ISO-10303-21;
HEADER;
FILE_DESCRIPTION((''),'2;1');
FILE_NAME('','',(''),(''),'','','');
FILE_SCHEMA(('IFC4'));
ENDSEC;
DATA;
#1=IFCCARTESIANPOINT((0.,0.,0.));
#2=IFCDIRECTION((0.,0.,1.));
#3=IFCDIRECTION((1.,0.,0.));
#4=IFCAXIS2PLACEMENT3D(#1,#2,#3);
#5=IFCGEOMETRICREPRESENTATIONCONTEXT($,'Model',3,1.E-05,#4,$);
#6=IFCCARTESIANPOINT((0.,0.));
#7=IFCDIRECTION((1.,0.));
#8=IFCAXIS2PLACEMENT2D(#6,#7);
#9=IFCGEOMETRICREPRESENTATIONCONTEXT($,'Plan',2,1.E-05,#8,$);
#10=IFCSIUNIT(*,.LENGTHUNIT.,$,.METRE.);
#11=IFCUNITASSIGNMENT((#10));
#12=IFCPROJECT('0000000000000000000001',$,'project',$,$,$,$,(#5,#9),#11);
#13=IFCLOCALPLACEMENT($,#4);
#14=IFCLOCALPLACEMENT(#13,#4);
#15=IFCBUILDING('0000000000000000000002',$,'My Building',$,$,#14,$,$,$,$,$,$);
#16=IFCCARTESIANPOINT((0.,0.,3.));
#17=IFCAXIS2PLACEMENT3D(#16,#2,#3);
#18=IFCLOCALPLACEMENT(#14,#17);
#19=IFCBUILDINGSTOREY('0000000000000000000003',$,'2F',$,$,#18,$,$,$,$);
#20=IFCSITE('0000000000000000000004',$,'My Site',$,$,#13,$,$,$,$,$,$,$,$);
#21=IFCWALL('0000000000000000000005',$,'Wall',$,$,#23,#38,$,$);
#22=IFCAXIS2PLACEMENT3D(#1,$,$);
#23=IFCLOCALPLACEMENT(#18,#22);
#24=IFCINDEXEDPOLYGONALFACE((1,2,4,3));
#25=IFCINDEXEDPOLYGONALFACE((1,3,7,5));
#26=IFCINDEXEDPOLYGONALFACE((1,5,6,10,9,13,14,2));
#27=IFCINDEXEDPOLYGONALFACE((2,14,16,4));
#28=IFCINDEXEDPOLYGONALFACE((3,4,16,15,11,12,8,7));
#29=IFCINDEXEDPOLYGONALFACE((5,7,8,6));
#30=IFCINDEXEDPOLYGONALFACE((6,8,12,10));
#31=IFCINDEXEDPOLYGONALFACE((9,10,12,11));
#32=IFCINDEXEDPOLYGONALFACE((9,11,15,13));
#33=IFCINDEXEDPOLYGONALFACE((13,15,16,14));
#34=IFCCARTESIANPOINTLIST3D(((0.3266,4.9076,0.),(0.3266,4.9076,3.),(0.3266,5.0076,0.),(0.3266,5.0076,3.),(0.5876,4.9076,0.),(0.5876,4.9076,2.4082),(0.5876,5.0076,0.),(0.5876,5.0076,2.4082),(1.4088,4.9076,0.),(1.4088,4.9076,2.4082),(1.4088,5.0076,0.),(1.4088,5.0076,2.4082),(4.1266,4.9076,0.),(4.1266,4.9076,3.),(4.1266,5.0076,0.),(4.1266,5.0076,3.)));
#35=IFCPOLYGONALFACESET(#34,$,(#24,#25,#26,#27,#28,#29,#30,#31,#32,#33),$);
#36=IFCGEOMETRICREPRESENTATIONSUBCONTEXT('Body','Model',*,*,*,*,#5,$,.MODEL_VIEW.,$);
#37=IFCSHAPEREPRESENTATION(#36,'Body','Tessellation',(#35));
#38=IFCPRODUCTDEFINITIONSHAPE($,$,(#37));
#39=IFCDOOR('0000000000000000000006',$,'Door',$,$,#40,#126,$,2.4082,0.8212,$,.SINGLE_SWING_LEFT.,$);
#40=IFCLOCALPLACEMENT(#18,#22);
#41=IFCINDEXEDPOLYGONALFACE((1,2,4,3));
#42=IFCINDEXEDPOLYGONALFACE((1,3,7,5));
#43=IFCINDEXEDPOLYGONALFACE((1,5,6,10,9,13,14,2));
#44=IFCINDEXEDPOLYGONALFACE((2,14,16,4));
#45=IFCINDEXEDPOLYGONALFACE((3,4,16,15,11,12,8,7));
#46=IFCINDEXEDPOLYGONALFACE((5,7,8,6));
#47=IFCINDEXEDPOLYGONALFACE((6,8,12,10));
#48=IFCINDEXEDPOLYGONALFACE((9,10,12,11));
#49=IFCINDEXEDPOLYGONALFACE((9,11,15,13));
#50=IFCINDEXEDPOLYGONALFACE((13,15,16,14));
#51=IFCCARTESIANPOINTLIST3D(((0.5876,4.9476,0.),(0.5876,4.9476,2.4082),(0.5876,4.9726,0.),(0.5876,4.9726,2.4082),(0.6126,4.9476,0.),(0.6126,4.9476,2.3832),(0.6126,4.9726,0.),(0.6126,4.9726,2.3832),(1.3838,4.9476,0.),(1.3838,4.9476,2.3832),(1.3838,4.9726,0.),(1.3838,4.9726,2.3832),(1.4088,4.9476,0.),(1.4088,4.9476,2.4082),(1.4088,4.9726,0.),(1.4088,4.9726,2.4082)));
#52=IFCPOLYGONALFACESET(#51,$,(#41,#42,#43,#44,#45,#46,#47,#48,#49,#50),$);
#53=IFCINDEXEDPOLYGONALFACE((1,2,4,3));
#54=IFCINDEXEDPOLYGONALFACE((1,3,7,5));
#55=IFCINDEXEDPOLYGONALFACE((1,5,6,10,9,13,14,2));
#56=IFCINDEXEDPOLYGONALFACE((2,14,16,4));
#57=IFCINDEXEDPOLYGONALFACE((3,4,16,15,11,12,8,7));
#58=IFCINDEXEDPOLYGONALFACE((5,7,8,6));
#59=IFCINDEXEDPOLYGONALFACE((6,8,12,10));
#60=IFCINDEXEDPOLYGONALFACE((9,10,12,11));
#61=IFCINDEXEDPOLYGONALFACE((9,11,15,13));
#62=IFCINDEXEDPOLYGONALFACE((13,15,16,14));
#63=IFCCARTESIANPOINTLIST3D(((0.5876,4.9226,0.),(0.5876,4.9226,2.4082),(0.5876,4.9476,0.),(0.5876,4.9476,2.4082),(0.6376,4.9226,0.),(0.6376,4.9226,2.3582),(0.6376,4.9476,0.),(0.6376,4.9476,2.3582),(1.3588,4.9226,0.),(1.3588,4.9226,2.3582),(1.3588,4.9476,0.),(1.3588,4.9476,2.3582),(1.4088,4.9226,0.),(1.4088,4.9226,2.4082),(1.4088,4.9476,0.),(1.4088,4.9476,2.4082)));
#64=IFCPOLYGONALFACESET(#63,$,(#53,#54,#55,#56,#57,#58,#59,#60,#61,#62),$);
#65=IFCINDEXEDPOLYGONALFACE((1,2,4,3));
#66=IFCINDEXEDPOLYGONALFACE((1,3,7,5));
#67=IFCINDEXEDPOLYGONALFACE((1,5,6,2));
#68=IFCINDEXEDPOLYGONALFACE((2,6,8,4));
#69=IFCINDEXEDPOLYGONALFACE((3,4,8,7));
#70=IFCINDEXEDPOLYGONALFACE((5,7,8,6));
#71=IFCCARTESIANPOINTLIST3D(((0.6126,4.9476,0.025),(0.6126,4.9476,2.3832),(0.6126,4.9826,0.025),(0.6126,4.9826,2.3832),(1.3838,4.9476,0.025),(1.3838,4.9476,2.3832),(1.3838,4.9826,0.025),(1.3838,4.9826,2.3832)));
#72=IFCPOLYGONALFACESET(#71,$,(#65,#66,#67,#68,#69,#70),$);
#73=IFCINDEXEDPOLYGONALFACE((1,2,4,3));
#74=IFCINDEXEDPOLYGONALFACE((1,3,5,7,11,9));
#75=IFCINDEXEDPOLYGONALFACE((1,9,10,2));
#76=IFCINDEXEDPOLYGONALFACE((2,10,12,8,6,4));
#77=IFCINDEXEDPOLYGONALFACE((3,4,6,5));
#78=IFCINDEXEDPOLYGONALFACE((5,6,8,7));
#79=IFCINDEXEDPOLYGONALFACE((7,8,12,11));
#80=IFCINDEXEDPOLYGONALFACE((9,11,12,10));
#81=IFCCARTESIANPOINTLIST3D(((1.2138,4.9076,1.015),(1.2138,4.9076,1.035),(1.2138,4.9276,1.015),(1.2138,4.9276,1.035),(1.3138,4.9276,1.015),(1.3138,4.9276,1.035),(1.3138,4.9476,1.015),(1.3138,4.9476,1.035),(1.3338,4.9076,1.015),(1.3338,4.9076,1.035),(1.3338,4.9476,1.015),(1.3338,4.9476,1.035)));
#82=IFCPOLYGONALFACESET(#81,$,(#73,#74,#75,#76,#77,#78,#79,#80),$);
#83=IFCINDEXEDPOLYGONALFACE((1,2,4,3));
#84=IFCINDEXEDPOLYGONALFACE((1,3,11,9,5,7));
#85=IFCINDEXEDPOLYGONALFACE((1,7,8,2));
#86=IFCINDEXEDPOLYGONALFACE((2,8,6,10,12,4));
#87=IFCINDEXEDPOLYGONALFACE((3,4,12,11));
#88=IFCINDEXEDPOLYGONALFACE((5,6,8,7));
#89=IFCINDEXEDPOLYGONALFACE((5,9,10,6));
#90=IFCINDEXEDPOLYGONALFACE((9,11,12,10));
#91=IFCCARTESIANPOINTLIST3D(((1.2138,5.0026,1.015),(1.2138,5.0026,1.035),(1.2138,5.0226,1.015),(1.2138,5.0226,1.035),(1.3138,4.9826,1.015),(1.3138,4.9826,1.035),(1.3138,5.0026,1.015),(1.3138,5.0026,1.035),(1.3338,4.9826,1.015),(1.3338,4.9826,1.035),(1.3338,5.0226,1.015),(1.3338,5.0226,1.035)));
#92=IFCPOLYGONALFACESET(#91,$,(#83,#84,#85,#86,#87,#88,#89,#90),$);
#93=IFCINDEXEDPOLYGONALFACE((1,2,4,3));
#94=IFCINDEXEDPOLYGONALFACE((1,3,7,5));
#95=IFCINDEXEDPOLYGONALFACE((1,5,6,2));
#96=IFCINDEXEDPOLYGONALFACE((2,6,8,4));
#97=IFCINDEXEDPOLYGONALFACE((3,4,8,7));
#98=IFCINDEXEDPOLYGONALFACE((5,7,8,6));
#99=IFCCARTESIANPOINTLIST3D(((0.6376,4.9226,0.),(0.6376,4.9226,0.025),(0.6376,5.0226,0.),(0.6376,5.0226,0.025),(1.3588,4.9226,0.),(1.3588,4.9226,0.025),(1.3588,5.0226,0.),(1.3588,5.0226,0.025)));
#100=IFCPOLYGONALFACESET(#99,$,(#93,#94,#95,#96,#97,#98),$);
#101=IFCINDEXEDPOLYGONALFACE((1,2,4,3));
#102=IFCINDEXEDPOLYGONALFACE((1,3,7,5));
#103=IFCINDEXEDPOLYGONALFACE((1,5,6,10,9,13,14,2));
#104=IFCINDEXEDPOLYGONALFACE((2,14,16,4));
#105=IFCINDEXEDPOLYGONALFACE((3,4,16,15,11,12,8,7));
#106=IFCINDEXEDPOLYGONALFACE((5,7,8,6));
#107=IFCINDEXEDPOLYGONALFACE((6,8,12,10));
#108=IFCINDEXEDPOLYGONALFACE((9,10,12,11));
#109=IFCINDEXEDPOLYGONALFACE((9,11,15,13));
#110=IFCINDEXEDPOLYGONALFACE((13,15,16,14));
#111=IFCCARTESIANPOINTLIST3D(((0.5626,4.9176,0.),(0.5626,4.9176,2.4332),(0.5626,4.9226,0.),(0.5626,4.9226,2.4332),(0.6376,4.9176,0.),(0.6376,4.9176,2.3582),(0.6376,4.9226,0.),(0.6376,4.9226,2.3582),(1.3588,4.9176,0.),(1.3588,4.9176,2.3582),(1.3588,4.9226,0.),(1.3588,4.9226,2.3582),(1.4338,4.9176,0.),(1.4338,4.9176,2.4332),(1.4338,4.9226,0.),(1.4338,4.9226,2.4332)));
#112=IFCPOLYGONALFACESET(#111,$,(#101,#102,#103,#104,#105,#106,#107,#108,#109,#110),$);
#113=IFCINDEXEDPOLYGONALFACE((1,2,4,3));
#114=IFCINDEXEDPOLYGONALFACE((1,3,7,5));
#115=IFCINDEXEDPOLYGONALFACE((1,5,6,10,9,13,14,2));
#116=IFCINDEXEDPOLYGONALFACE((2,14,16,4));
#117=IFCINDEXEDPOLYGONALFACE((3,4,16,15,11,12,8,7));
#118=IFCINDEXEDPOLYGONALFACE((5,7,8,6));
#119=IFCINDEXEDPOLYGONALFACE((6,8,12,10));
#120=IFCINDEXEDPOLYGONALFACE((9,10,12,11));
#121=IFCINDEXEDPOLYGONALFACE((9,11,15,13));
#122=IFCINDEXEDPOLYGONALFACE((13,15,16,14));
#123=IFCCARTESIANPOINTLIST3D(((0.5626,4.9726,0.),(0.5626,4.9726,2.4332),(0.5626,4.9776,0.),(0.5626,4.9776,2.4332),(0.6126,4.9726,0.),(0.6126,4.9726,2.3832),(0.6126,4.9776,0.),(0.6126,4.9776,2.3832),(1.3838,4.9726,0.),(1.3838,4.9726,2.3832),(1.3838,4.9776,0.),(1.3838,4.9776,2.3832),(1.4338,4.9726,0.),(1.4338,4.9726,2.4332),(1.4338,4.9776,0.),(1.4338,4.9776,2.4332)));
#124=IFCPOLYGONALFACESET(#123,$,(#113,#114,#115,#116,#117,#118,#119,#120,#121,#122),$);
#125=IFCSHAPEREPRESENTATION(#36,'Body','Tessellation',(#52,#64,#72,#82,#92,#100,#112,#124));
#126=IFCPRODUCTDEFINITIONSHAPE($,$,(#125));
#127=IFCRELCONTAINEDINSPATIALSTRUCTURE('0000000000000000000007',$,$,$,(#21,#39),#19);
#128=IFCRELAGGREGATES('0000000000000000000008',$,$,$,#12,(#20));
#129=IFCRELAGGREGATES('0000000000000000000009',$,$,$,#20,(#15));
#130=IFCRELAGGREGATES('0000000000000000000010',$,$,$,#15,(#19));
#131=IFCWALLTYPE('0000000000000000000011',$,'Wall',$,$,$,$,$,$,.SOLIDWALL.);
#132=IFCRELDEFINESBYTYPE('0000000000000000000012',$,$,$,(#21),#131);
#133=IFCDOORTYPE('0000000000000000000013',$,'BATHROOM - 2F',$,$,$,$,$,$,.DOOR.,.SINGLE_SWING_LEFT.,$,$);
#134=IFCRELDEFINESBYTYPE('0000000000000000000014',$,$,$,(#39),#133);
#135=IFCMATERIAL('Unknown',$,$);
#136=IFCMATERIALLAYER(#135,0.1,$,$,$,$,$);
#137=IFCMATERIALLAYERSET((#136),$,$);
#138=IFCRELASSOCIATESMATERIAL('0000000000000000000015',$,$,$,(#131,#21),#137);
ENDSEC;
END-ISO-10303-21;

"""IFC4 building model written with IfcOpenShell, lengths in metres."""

from ifc_helpers import new_model, entity, si_unit, frame, origin_with_axes, origin_2d_with_axis, place, context, subcontext, project, spatial, line, indexed_curve, outline, extrude, shape, source, transform, mapped, material, layer, layer_set, layer_usage, type_object, type_shapes, element, fill, save


model = new_model("IFC4")

# Units and contexts
model_context = context("Model", 3, precision=1e-05, world=origin_with_axes())
plan_context = context("Plan", 2, precision=1e-05, world=origin_2d_with_axis())
body_context_1 = subcontext(model_context, "Body", "Model", "MODEL_VIEW")
body_context_2 = subcontext(plan_context, "Body", "Plan", "PLAN_VIEW")
ifc_project = project(units=[si_unit("LENGTHUNIT", "METRE")], contexts=[model_context, plan_context])

# Site, building, storey
site_placement = place(None, origin_with_axes())
site = spatial("IfcSite", under=ifc_project, at=site_placement, Name="My Site")
building_placement = place(site_placement, origin_with_axes())
building = spatial("IfcBuilding", under=site, at=building_placement, Name="My Building")
storey_placement = place(building_placement, frame((0.0, 0.0, 3.0), z_axis=(0.0, 0.0, 1.0), x_axis=(1.0, 0.0, 0.0)))
storey = spatial("IfcBuildingStorey", under=building, at=storey_placement, Name="2F")

# Shared definitions
ifc_material = material(Name="Unknown")

# Shared definitions
ifc_layer_1 = layer(ifc_material, 0.1)
ifc_layer_set_1 = layer_set([ifc_layer_1])
wall_type = type_object("IfcWallType", Name="Wall", PredefinedType="SOLIDWALL", material=ifc_layer_set_1)

# Wall, opening, door
ifc_layer_usage_1 = layer_usage(ifc_layer_set_1, "AXIS2", "POSITIVE", 0.0)
wall_1_placement = place(storey_placement, frame((0.3266, 4.9076, 0.0), z_axis=(0.0, 0.0, 1.0), x_axis=(1.0, 0.0, 0.0)))
wall_1 = element("IfcWall", 1, at=wall_1_placement, inside=storey, type_object=wall_type, material=ifc_layer_usage_1, Name="Wall", context=body_context_1, shape_type="SweptSolid", body=[
    extrude(outline(indexed_curve([(0.0, 0.0), (0.0, 0.1), (3.8, 0.1), (3.8, 0.0)], segments=[line(1, 2, 3, 4, 1)])), origin_with_axes(), (0.0, 0.0, 1.0), 3.0),
])
shared_shape_1 = source(origin_with_axes(), body_context_1, "Body", "SweptSolid", [
    extrude(outline(indexed_curve([(0.0, 0.0), (0.8212, 0.0), (0.8212, 2.4082), (0.0, 2.4082)], segments=[line(1, 2, 3, 4, 1)])), frame((0.0, -0.6, 0.0), z_axis=(0.0, -1.0, 0.0), x_axis=(1.0, 0.0, 0.0)), (0.0, 0.0, -1.0), 1.2),
])
opening_1_placement = place(wall_1_placement, frame((0.261, 0.015, 0.0), z_axis=(0.0, 0.0, 1.0), x_axis=(1.0, 0.0, 0.0)))
opening_1 = element("IfcOpeningElement", 2, at=opening_1_placement, cuts=wall_1, PredefinedType="OPENING", context=body_context_1, shape_type="MappedRepresentation", body=[
    mapped(shared_shape_1, transform((0.0, 0.0, 0.0), x_axis=(1.0, 0.0, 0.0), y_axis=(0.0, 1.0, 0.0), z_axis=(0.0, 0.0, 1.0), scale=1.0)),
])
door_type_1 = type_object("IfcDoorType", Name="BATHROOM - 2F", OperationType="SINGLE_SWING_LEFT", PredefinedType="DOOR")
shared_shape_2 = source(origin_with_axes(), body_context_1, "Body", "SweptSolid", [
    extrude(outline(indexed_curve([(0.0, 0.0), (0.0, 2.4082), (0.8212, 2.4082), (0.8212, 0.0), (0.7962, 0.0), (0.7962, 2.3832), (0.025, 2.3832), (0.025, 0.0)], segments=[line(1, 2, 3, 4, 5, 6, 7, 8, 1)])), frame((0.0, 0.025, 0.0), z_axis=(0.0, -1.0, 0.0), x_axis=(1.0, 0.0, 0.0)), (0.0, 0.0, -1.0), 0.025),
    extrude(outline(indexed_curve([(0.0, 0.0), (0.0, 2.4082), (0.8212, 2.4082), (0.8212, 0.0), (0.7712, 0.0), (0.7712, 2.3582), (0.05, 2.3582), (0.05, 0.0)], segments=[line(1, 2, 3, 4, 5, 6, 7, 8, 1)])), frame((0.0, 0.0, 0.0), z_axis=(0.0, -1.0, 0.0), x_axis=(1.0, 0.0, 0.0)), (0.0, 0.0, -1.0), 0.025),
    extrude(outline(indexed_curve([(0.0, 0.0), (0.7712, 0.0), (0.7712, 0.035), (0.0, 0.035)], segments=[line(1, 2, 3, 4, 1)])), frame((0.025, 0.025, 0.025), z_axis=(0.0, 0.0, 1.0), x_axis=(1.0, 0.0, 0.0)), (0.0, 0.0, 1.0), 2.3582),
    extrude(outline(indexed_curve([(0.0, 0.0), (0.0, -0.04), (-0.12, -0.04), (-0.12, -0.02), (-0.02, -0.02), (-0.02, 0.0)], segments=[line(1, 2, 3, 4, 5, 6, 1)])), frame((0.7462, 0.025, 1.015), z_axis=(0.0, 0.0, 1.0), x_axis=(1.0, 0.0, 0.0)), (0.0, 0.0, 1.0), 0.02),
    extrude(outline(indexed_curve([(0.0, 0.0), (0.0, 0.04), (-0.12, 0.04), (-0.12, 0.02), (-0.02, 0.02), (-0.02, 0.0)], segments=[line(1, 2, 3, 4, 5, 6, 1)])), frame((0.7462, 0.06, 1.015), z_axis=(0.0, 0.0, 1.0), x_axis=(1.0, 0.0, 0.0)), (0.0, 0.0, 1.0), 0.02),
    extrude(outline(indexed_curve([(0.0, 0.0), (0.7212, 0.0), (0.7212, 0.1), (0.0, 0.1)], segments=[line(1, 2, 3, 4, 1)])), frame((0.05, 0.0, 0.0), z_axis=(0.0, 0.0, 1.0), x_axis=(1.0, 0.0, 0.0)), (0.0, 0.0, 1.0), 0.025),
    extrude(outline(indexed_curve([(0.0, 0.0), (0.0, 2.4332), (0.8712, 2.4332), (0.8712, 0.0), (0.7962, 0.0), (0.7962, 2.3582), (0.075, 2.3582), (0.075, 0.0)], segments=[line(1, 2, 3, 4, 5, 6, 7, 8, 1)])), frame((-0.025, -0.005, 0.0), z_axis=(0.0, -1.0, 0.0), x_axis=(1.0, 0.0, 0.0)), (0.0, 0.0, -1.0), 0.005),
    extrude(outline(indexed_curve([(0.0, 0.0), (0.0, 2.4332), (0.8712, 2.4332), (0.8712, 0.0), (0.8212, 0.0), (0.8212, 2.3832), (0.05, 2.3832), (0.05, 0.0)], segments=[line(1, 2, 3, 4, 5, 6, 7, 8, 1)])), frame((-0.025, 0.05, 0.0), z_axis=(0.0, -1.0, 0.0), x_axis=(1.0, 0.0, 0.0)), (0.0, 0.0, -1.0), 0.005),
])
shared_shape_3 = source(origin_with_axes(), body_context_2, "Body", "Curve2D", [
    entity("IfcIndexedPolyCurve", entity("IfcCartesianPointList2D", [[0.0, 0.0], [0.0, 0.05], [0.025, 0.05], [0.025, 0.025], [0.05, 0.025], [0.05, 0.0]]), [entity("IfcLineIndex", [1, 2, 3, 4, 5, 6, 1])]),
    entity("IfcIndexedPolyCurve", entity("IfcCartesianPointList2D", [[0.8212, 0.0], [0.8212, 0.05], [0.7962, 0.05], [0.7962, 0.025], [0.7712, 0.025], [0.7712, 0.0]]), [entity("IfcLineIndex", [1, 2, 3, 4, 5, 6, 1])]),
    entity("IfcTrimmedCurve", entity("IfcEllipse", entity("IfcAxis2Placement2D", entity("IfcCartesianPoint", [0.06, 0.05]), entity("IfcDirection", [1.0, 0.0])), 0.7362, 0.7712), [entity("IfcCartesianPoint", [0.7962, 0.05])], [entity("IfcCartesianPoint", [0.06, 0.8212])], True, "CARTESIAN"),
    entity("IfcIndexedPolyCurve", entity("IfcCartesianPointList2D", [[0.025, 0.05], [0.06, 0.05], [0.06, 0.8212], [0.025, 0.8212]]), [entity("IfcLineIndex", [1, 2, 3, 4, 1])]),
])
type_shapes(door_type_1, [shared_shape_2, shared_shape_3])
door_1_placement = place(opening_1_placement, frame((0.0, 0.0, 0.0), z_axis=(0.0, 0.0, 1.0), x_axis=(1.0, 0.0, 0.0)))
door_1 = element("IfcDoor", 3, at=door_1_placement, inside=storey, type_object=door_type_1, Name="Door", OperationType="SINGLE_SWING_LEFT", OverallHeight=2.4082, OverallWidth=0.8212, shapes=[
    shape(body_context_1, "Body", "MappedRepresentation", [mapped(shared_shape_2, transform((0.0, 0.0, 0.0), x_axis=(1.0, 0.0, 0.0), y_axis=(0.0, 1.0, 0.0), z_axis=(0.0, 0.0, 1.0), scale=1.0))]),
    shape(body_context_2, "Body", "MappedRepresentation", [mapped(shared_shape_3, transform((0.0, 0.0, 0.0), x_axis=(1.0, 0.0, 0.0), y_axis=(0.0, 1.0, 0.0), z_axis=(0.0, 0.0, 1.0), scale=1.0))]),
])
fill(opening_1, door_1)

save(model, "model.ifc")
